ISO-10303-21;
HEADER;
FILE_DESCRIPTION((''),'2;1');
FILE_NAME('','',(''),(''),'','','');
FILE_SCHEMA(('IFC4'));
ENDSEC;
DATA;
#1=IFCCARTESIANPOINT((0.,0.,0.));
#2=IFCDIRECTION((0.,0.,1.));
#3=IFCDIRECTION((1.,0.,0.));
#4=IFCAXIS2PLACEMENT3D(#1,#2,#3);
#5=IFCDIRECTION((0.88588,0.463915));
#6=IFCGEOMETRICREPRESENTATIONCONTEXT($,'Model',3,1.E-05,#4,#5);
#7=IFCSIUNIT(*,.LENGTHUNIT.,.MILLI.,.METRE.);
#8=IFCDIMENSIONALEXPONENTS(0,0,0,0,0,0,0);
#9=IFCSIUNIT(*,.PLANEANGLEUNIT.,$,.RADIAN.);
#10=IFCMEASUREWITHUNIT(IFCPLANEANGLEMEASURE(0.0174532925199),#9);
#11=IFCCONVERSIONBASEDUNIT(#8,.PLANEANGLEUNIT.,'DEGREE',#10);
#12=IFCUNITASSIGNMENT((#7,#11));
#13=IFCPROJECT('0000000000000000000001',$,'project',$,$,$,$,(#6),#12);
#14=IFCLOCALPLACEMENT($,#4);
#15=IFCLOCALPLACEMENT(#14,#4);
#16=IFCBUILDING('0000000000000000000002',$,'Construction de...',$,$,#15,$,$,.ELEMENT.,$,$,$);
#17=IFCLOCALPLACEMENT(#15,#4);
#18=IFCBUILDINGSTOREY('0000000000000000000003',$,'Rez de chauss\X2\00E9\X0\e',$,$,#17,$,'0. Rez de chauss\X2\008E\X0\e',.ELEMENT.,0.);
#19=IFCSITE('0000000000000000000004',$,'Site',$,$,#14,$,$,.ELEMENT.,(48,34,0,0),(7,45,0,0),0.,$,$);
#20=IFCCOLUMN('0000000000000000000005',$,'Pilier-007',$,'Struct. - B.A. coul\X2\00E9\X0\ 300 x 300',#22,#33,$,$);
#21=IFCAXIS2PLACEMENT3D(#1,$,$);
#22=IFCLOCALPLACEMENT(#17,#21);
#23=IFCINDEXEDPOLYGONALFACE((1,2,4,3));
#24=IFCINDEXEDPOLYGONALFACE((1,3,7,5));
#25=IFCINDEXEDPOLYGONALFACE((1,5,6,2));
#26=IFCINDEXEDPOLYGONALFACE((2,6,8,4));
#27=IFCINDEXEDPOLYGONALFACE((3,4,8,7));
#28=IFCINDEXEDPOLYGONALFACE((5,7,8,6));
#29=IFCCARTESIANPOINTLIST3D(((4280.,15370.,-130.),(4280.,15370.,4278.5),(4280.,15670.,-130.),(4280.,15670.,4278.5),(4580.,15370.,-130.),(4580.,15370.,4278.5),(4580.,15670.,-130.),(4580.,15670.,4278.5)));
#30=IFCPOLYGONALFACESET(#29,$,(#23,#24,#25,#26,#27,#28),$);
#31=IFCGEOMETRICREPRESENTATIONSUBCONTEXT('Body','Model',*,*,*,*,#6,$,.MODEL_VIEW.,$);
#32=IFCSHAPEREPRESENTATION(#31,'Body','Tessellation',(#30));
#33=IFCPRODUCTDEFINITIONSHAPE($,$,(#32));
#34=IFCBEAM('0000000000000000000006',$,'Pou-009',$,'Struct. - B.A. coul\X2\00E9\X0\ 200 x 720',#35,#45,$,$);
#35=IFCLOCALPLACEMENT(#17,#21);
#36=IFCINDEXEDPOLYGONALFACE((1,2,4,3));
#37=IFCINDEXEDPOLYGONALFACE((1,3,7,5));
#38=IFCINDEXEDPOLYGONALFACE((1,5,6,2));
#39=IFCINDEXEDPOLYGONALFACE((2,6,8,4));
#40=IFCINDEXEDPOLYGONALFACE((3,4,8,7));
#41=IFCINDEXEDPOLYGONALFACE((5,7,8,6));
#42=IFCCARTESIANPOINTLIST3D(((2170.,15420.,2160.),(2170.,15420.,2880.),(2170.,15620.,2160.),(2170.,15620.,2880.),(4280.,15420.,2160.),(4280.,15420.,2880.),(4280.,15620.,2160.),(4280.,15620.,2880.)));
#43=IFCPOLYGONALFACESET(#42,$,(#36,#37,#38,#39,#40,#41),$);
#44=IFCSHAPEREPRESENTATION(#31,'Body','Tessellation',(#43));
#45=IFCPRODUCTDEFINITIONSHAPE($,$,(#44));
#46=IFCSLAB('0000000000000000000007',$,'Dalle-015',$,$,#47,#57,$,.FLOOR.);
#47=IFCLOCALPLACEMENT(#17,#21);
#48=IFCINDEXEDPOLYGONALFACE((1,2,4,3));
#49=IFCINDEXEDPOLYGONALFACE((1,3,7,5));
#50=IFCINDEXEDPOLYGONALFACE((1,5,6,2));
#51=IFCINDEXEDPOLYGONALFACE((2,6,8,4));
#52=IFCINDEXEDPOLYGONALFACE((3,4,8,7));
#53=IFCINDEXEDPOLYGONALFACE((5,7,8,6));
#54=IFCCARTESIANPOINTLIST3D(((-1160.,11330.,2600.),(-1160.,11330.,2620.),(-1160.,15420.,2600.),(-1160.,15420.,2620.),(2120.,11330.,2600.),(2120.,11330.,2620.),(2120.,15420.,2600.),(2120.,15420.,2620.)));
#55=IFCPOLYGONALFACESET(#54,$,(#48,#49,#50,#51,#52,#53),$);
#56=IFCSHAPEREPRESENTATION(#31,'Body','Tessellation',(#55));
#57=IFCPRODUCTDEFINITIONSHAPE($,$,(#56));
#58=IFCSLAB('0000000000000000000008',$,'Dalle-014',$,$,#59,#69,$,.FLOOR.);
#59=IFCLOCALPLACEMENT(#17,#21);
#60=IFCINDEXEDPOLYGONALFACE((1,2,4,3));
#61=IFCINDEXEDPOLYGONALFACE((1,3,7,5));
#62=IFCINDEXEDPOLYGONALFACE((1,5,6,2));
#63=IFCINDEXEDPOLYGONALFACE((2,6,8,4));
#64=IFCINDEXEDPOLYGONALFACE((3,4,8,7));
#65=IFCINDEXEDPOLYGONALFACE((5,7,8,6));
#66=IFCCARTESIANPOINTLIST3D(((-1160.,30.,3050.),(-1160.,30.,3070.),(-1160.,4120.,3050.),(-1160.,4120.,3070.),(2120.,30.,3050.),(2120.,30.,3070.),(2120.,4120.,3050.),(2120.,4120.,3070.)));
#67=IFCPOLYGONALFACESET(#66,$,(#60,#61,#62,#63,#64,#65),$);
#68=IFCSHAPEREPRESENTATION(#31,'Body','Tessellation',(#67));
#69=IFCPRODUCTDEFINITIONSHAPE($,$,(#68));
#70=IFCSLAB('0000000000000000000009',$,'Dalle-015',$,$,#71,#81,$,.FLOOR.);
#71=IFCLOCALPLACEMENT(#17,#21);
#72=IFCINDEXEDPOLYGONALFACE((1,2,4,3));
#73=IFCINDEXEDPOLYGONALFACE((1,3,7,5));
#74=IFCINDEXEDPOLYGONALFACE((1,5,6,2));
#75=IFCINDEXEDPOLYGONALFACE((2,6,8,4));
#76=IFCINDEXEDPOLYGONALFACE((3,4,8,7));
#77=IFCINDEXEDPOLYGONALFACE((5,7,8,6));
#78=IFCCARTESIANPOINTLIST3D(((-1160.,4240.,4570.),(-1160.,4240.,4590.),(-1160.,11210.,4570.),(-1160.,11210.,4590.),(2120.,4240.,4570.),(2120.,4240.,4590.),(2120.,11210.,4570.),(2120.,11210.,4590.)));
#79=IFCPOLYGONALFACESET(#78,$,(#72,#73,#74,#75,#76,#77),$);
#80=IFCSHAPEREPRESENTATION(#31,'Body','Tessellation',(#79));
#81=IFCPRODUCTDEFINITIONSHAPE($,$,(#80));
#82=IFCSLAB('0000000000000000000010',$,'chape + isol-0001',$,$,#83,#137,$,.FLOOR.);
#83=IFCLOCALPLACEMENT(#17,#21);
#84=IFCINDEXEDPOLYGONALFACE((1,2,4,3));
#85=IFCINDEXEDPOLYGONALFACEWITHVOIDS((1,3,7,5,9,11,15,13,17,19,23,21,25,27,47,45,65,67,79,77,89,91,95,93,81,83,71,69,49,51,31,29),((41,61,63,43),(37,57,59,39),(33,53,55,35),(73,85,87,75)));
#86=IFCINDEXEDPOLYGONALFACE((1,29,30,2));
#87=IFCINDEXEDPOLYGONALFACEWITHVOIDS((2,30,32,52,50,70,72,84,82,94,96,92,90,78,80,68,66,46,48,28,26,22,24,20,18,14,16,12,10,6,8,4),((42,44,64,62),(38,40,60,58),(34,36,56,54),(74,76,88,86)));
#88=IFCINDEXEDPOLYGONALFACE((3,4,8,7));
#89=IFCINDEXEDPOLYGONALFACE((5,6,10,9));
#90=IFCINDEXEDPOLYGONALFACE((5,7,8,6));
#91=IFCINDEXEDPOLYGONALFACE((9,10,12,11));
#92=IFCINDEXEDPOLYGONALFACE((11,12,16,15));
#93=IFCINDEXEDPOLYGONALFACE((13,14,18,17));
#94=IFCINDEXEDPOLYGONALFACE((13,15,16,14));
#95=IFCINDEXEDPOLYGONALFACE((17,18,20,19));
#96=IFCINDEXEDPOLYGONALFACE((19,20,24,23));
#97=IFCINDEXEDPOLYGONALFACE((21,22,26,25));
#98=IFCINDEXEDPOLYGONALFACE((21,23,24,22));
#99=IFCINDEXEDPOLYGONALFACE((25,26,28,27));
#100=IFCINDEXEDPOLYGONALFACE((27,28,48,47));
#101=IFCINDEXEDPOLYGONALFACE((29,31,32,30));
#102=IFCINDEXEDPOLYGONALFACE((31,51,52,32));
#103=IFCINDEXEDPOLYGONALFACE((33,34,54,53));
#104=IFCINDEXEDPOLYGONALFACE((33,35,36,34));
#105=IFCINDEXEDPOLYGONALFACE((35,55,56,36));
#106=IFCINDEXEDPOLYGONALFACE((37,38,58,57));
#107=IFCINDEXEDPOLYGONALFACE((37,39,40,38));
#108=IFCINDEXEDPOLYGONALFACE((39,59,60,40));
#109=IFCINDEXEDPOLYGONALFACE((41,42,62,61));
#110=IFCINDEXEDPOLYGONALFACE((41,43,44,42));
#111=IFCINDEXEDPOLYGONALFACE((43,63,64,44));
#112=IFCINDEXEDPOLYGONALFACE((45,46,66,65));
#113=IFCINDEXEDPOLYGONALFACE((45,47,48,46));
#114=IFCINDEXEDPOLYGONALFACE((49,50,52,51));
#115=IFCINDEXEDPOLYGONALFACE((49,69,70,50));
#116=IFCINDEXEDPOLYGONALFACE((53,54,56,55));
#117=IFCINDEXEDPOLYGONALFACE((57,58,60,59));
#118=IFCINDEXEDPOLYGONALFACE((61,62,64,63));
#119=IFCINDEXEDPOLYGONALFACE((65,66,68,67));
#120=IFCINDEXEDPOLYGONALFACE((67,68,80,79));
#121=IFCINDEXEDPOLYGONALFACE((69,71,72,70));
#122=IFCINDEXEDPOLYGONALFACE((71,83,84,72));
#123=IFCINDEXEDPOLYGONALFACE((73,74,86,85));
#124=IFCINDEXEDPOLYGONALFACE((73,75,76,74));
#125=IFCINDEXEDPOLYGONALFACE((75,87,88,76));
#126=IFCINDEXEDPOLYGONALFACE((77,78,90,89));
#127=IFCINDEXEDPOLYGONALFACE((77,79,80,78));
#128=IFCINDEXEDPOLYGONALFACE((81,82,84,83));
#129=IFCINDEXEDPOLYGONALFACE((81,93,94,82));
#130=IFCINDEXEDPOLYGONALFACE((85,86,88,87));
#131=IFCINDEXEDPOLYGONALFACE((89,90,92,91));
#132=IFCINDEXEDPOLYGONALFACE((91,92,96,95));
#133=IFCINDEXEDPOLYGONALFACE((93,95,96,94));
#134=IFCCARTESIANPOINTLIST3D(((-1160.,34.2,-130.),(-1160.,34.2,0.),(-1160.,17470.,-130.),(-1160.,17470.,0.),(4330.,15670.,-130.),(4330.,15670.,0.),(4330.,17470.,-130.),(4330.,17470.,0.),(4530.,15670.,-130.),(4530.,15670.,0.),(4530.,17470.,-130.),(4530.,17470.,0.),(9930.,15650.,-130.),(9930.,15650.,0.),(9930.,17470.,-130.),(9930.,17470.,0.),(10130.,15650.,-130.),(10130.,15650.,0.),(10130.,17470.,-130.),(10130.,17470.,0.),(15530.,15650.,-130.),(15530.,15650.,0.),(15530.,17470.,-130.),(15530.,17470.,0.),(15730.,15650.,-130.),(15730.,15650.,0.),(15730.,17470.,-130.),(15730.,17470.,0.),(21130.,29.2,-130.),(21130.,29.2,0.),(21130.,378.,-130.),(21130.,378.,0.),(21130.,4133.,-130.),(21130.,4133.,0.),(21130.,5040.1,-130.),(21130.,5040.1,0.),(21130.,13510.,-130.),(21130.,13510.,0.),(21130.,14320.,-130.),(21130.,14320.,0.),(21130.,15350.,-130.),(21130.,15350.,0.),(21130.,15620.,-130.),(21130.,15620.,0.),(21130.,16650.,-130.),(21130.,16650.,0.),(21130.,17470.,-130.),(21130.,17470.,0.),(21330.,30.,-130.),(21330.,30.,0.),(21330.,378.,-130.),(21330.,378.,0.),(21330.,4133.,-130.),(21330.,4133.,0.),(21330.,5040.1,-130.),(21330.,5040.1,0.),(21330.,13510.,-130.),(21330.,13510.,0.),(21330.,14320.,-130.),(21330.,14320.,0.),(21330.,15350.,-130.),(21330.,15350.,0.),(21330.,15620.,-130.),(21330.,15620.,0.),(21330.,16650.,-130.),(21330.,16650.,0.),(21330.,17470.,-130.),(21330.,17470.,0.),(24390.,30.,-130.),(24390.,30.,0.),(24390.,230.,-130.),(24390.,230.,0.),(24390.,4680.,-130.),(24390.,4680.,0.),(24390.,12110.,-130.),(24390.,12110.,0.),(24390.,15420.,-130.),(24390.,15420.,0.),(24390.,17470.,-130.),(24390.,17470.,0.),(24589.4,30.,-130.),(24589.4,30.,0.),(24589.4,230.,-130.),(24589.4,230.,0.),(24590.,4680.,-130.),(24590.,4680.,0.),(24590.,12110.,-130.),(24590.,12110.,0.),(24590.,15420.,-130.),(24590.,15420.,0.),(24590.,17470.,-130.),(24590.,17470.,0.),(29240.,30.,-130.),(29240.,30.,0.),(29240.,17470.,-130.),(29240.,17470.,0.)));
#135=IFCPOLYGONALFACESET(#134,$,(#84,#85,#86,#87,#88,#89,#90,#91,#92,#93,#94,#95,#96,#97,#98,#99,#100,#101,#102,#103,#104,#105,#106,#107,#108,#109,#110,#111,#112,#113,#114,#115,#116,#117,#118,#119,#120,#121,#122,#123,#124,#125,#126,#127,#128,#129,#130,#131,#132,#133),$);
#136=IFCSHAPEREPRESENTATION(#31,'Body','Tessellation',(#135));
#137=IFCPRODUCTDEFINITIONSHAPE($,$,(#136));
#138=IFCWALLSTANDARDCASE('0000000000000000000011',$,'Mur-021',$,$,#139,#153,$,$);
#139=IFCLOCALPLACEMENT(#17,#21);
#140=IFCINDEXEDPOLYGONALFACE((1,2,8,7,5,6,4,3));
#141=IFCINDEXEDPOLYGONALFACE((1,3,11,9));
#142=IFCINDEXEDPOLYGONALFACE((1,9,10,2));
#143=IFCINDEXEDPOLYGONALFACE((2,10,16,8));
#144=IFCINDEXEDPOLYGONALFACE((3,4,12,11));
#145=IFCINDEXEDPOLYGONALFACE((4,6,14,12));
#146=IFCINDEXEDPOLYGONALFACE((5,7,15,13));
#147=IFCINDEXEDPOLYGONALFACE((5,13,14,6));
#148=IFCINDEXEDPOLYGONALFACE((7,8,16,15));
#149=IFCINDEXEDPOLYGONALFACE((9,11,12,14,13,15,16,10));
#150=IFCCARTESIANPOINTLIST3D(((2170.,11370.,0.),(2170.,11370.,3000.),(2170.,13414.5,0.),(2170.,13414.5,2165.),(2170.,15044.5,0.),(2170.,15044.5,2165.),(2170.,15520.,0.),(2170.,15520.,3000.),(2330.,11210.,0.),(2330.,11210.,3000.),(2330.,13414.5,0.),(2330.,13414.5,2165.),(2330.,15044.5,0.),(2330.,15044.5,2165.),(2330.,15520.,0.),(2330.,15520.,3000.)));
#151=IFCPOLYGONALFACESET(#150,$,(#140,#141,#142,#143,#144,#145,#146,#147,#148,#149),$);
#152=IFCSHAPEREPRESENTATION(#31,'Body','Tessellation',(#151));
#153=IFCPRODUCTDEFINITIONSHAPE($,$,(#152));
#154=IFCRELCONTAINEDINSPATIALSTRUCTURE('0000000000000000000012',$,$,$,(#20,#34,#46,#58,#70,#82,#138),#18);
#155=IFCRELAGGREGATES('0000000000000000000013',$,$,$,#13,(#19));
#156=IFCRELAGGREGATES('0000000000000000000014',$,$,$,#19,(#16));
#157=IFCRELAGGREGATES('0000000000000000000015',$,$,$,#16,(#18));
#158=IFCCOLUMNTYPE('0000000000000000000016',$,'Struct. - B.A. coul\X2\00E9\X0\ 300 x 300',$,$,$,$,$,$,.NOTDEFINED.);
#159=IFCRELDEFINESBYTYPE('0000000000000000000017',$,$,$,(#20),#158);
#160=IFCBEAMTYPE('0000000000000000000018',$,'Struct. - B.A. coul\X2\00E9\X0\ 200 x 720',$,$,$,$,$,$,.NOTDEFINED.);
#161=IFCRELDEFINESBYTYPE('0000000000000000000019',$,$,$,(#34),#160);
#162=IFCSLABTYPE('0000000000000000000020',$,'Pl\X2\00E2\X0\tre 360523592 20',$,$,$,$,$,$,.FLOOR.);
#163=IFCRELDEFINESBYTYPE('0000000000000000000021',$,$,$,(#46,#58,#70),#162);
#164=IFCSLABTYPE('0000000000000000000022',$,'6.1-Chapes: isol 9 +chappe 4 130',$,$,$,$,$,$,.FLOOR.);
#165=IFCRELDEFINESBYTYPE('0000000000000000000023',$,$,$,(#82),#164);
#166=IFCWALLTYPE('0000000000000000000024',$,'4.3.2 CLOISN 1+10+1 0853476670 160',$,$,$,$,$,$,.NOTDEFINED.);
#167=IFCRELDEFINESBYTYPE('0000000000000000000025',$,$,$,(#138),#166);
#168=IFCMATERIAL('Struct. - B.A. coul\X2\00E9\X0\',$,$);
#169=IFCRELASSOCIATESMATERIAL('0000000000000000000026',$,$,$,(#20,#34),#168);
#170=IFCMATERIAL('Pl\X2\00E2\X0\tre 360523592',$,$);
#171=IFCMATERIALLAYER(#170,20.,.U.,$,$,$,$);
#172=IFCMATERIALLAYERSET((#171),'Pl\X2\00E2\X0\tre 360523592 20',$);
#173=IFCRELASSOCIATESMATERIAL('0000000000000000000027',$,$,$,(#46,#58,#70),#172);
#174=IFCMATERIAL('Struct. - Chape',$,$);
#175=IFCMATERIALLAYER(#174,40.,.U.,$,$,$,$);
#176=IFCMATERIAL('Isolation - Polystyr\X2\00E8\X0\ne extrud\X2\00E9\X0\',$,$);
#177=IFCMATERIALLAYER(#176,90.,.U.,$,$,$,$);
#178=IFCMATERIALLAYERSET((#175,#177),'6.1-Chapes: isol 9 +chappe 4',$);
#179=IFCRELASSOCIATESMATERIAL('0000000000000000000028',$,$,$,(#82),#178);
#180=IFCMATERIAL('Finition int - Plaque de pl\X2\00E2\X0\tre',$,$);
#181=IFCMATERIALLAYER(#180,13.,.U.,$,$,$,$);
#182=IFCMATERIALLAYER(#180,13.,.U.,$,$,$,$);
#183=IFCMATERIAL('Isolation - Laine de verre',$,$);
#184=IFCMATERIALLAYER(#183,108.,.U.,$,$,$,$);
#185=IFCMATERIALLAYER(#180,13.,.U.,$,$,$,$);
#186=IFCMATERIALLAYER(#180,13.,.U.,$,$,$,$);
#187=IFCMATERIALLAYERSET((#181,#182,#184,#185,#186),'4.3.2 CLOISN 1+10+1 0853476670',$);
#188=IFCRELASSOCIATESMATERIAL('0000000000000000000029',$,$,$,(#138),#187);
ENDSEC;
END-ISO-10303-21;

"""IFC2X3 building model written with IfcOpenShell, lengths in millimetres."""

from ifc_helpers import new_model, entity, si_unit, converted_unit, direction, frame, frame_2d, origin_with_axes, origin_2d_with_axis, place, context, subcontext, project, spatial, polyline, rectangle, outline, extrude, material, layer, layer_set, layer_usage, type_object, element, save


model = new_model("IFC2X3")

# Units and contexts
model_context = context("Model", 3, precision=1e-05, world=origin_with_axes(), true_north=direction((0.88588, 0.463915)))
body_context = subcontext(model_context, "Body", "Model", "MODEL_VIEW")
ifc_project = project(units=[si_unit("LENGTHUNIT", "METRE", prefix="MILLI"), converted_unit("PLANEANGLEUNIT", "DEGREE", entity("IfcPlaneAngleMeasure", 0.0174532925199), si_unit("PLANEANGLEUNIT", "RADIAN"), dimensions=[0, 0, 0, 0, 0, 0, 0])], contexts=[model_context])

# Site, building, storey
site_placement = place(None, origin_with_axes())
site = spatial("IfcSite", under=ifc_project, at=site_placement, Name="Site", CompositionType="ELEMENT", RefLatitude=(48, 34, 0, 0), RefLongitude=(7, 45, 0, 0), RefElevation=0.0)
building_placement = place(site_placement, origin_with_axes())
building = spatial("IfcBuilding", under=site, at=building_placement, Name="Construction de...", CompositionType="ELEMENT")
storey_placement = place(building_placement, origin_with_axes())
storey = spatial("IfcBuildingStorey", under=building, at=storey_placement, Name="Rez de chaussée", LongName="0. Rez de chauss\u008ee", CompositionType="ELEMENT", Elevation=0.0)

# Column
ifc_material_1 = material(Name="Struct. - B.A. coulé")
column_type = type_object("IfcColumnType", Name="Struct. - B.A. coulé 300 x 300", PredefinedType="NOTDEFINED")
column_placement = place(storey_placement, frame((4430.0, 15520.0, -130.0), z_axis=(0.0, 0.0, 1.0), x_axis=(1.0, 0.0, 0.0)))
element("IfcColumn", 1, at=column_placement, inside=storey, type_object=column_type, material=ifc_material_1, Name="Pilier-007", ObjectType="Struct. - B.A. coulé 300 x 300", context=body_context, shape_type="SweptSolid", body=[
    extrude(rectangle(XDim=300.0, YDim=300.0, at=origin_2d_with_axis()), origin_with_axes(), (0.0, 0.0, 1.0), 4408.5),
])

# Beam
beam_type = type_object("IfcBeamType", Name="Struct. - B.A. coulé 200 x 720", PredefinedType="NOTDEFINED")
beam_placement = place(storey_placement, frame((4280.0, 15620.0, 2880.0), z_axis=(0.0, 0.0, 1.0), x_axis=(0.0, 1.0, 0.0)))
element("IfcBeam", 2, at=beam_placement, inside=storey, type_object=beam_type, material=ifc_material_1, Name="Pou-009", ObjectType="Struct. - B.A. coulé 200 x 720", context=body_context, shape_type="SweptSolid", body=[
    extrude(rectangle(XDim=720.0, YDim=200.0, at=frame_2d((-360.0, -100.0), x_axis=(1.0, 0.0))), frame((0.0, 0.0, 0.0), z_axis=(0.0, 1.0, 0.0), x_axis=(0.0, 0.0, 1.0)), (0.0, 0.0, 1.0), 2110.0),
])

# Slabs
ifc_material_2 = material(Name="Plâtre 360523592")
ifc_layer_1 = layer(ifc_material_2, 20.0, ventilated="UNKNOWN")
ifc_layer_set_1 = layer_set([ifc_layer_1], Name="Plâtre 360523592 20")
ifc_layer_usage_1 = layer_usage(ifc_layer_set_1, "AXIS3", "NEGATIVE", 20.0)
slab_type_1 = type_object("IfcSlabType", Name="Plâtre 360523592 20", PredefinedType="FLOOR")
slab_1_placement = place(storey_placement, frame((2120.0, 11330.0, 2620.0), z_axis=(0.0, 0.0, 1.0), x_axis=(1.0, 0.0, 0.0)))
element("IfcSlab", 3, at=slab_1_placement, inside=storey, type_object=slab_type_1, material=ifc_layer_usage_1, Name="Dalle-015", PredefinedType="FLOOR", context=body_context, shape_type="SweptSolid", body=[
    extrude(outline(polyline([(0.0, 0.0), (0.0, 4090.0), (-3280.0, 4090.0), (-3280.0, 0.0), (0.0, 0.0)])), frame((0.0, 0.0, -20.0), z_axis=(0.0, 0.0, 1.0), x_axis=(1.0, 0.0, 0.0)), (0.0, 0.0, 1.0), 20.0),
])
ifc_layer_usage_2 = layer_usage(ifc_layer_set_1, "AXIS3", "NEGATIVE", 20.0)
slab_2_placement = place(storey_placement, frame((2120.0, 4120.0, 3070.0), z_axis=(0.0, 0.0, 1.0), x_axis=(1.0, 0.0, 0.0)))
element("IfcSlab", 4, at=slab_2_placement, inside=storey, type_object=slab_type_1, material=ifc_layer_usage_2, Name="Dalle-014", PredefinedType="FLOOR", context=body_context, shape_type="SweptSolid", body=[
    extrude(outline(polyline([(0.0, 0.0), (-3280.0, 0.0), (-3280.0, -4090.0), (0.0, -4090.0), (0.0, 0.0)])), frame((0.0, 0.0, -20.0), z_axis=(0.0, 0.0, 1.0), x_axis=(1.0, 0.0, 0.0)), (0.0, 0.0, 1.0), 20.0),
])
ifc_layer_usage_3 = layer_usage(ifc_layer_set_1, "AXIS3", "NEGATIVE", 20.0)
slab_3_placement = place(storey_placement, frame((-1160.0, 11210.0, 4590.0), z_axis=(0.0, 0.0, 1.0), x_axis=(1.0, 0.0, 0.0)))
element("IfcSlab", 5, at=slab_3_placement, inside=storey, type_object=slab_type_1, material=ifc_layer_usage_3, Name="Dalle-015", PredefinedType="FLOOR", context=body_context, shape_type="SweptSolid", body=[
    extrude(outline(polyline([(0.0, 0.0), (0.0, -6970.0), (3280.0, -6970.0), (3280.0, 0.0), (0.0, 0.0)])), frame((0.0, 0.0, -20.0), z_axis=(0.0, 0.0, 1.0), x_axis=(1.0, 0.0, 0.0)), (0.0, 0.0, 1.0), 20.0),
])

# Slab, openings
ifc_material_3 = material(Name="Struct. - Chape")
ifc_layer_2 = layer(ifc_material_3, 40.0, ventilated="UNKNOWN")
ifc_material_4 = material(Name="Isolation - Polystyrène extrudé")
ifc_layer_3 = layer(ifc_material_4, 90.0, ventilated="UNKNOWN")
ifc_layer_set_2 = layer_set([ifc_layer_2, ifc_layer_3], Name="6.1-Chapes: isol 9 +chappe 4")
ifc_layer_usage_4 = layer_usage(ifc_layer_set_2, "AXIS3", "NEGATIVE", 130.0)
slab_type_2 = type_object("IfcSlabType", Name="6.1-Chapes: isol 9 +chappe 4 130", PredefinedType="FLOOR")
slab_4_placement = place(storey_placement, frame((-1160.0, 34.2, 0.0), z_axis=(0.0, 0.0, 1.0), x_axis=(1.0, 0.0, 0.0)))
slab_4 = element("IfcSlab", 6, at=slab_4_placement, inside=storey, type_object=slab_type_2, material=ifc_layer_usage_4, Name="chape + isol-0001", PredefinedType="FLOOR", context=body_context, shape_type="SweptSolid", body=[
    extrude(outline(polyline([(0.0, 0.0), (22290.0, -5.0), (22290.0, 343.8), (22490.0, 343.8), (22490.0, -4.2), (25550.0, -4.2), (25550.0, 195.8), (25749.4, 195.8), (25749.4, -4.2), (30400.0, -4.2), (30400.0, 17435.8), (25750.0, 17435.8), (25750.0, 15385.8), (25550.0, 15385.8), (25550.0, 17435.8), (22490.0, 17435.8), (22490.0, 16615.8), (22290.0, 16615.8), (22290.0, 17435.8), (16890.0, 17435.8), (16890.0, 15615.8), (16690.0, 15615.8), (16690.0, 17435.8), (11290.0, 17435.8), (11290.0, 15615.8), (11090.0, 15615.8), (11090.0, 17435.8), (5690.0, 17435.8), (5690.0, 15635.8), (5490.0, 15635.8), (5490.0, 17435.8), (0.0, 17435.8), (0.0, 0.0)])), frame((0.0, 0.0, -130.0), z_axis=(0.0, 0.0, 1.0), x_axis=(1.0, 0.0, 0.0)), (0.0, 0.0, 1.0), 130.0),
])
opening_1_placement = place(slab_4_placement, origin_with_axes())
element("IfcOpeningElement", 7, at=opening_1_placement, cuts=slab_4, context=body_context, shape_type="SweptSolid", body=[
    extrude(outline(polyline([(22290.0, 15585.8), (22290.0, 15315.8), (22490.0, 15315.8), (22490.0, 15585.8), (22290.0, 15585.8)])), frame((0.0, 0.0, -130.0), z_axis=(0.0, 0.0, 1.0), x_axis=(1.0, 0.0, 0.0)), (0.0, 0.0, 1.0), 130.0),
])
opening_2_placement = place(slab_4_placement, origin_with_axes())
element("IfcOpeningElement", 8, at=opening_2_placement, cuts=slab_4, context=body_context, shape_type="SweptSolid", body=[
    extrude(outline(polyline([(22290.0, 4098.8), (22490.0, 4098.8), (22490.0, 5005.9), (22290.0, 5005.9), (22290.0, 4098.8)])), frame((0.0, 0.0, -130.0), z_axis=(0.0, 0.0, 1.0), x_axis=(1.0, 0.0, 0.0)), (0.0, 0.0, 1.0), 130.0),
])
opening_3_placement = place(slab_4_placement, origin_with_axes())
element("IfcOpeningElement", 9, at=opening_3_placement, cuts=slab_4, context=body_context, shape_type="SweptSolid", body=[
    extrude(outline(polyline([(22290.0, 13475.8), (22490.0, 13475.8), (22490.0, 14285.8), (22290.0, 14285.8), (22290.0, 13475.8)])), frame((0.0, 0.0, -130.0), z_axis=(0.0, 0.0, 1.0), x_axis=(1.0, 0.0, 0.0)), (0.0, 0.0, 1.0), 130.0),
])
opening_4_placement = place(slab_4_placement, origin_with_axes())
element("IfcOpeningElement", 10, at=opening_4_placement, cuts=slab_4, context=body_context, shape_type="SweptSolid", body=[
    extrude(outline(polyline([(25550.0, 12075.8), (25550.0, 4645.8), (25750.0, 4645.8), (25750.0, 12075.8), (25550.0, 12075.8)])), frame((0.0, 0.0, -130.0), z_axis=(0.0, 0.0, 1.0), x_axis=(1.0, 0.0, 0.0)), (0.0, 0.0, 1.0), 130.0),
])

# Shared definitions
ifc_material_5 = material(Name="Finition int - Plaque de plâtre")
ifc_layer_4 = layer(ifc_material_5, 13.0, ventilated="UNKNOWN")
ifc_layer_5 = layer(ifc_material_5, 13.0, ventilated="UNKNOWN")
ifc_material_6 = material(Name="Isolation - Laine de verre")
ifc_layer_6 = layer(ifc_material_6, 108.0, ventilated="UNKNOWN")
ifc_layer_7 = layer(ifc_material_5, 13.0, ventilated="UNKNOWN")
ifc_layer_8 = layer(ifc_material_5, 13.0, ventilated="UNKNOWN")
ifc_layer_set_3 = layer_set([ifc_layer_4, ifc_layer_5, ifc_layer_6, ifc_layer_7, ifc_layer_8], Name="4.3.2 CLOISN 1+10+1 0853476670")
wall_type_1 = type_object("IfcWallType", Name="4.3.2 CLOISN 1+10+1 0853476670 160", PredefinedType="NOTDEFINED")

# Wall, opening
ifc_layer_usage_5 = layer_usage(ifc_layer_set_3, "AXIS2", "NEGATIVE", 80.0)
wall_1_placement = place(storey_placement, frame((2250.0, 11290.0, 0.0), z_axis=(0.0, 0.0, 1.0), x_axis=(0.0, 1.0, 0.0)))
wall_1 = element("IfcWallStandardCase", 11, at=wall_1_placement, inside=storey, type_object=wall_type_1, material=ifc_layer_usage_5, Name="Mur-021", context=body_context, shape_type="SweptSolid", body=[
    extrude(outline(polyline([(-80.0, -80.0), (4230.0, -80.0), (4230.0, 80.0), (80.0, 80.0), (-80.0, -80.0)])), origin_with_axes(), (0.0, 0.0, 1.0), 3000.0),
])
opening_5_placement = place(wall_1_placement, frame((2939.5, 0.0, 0.0), z_axis=(0.0, 0.0, 1.0), x_axis=(1.0, 0.0, 0.0)))
element("IfcOpeningElement", 12, at=opening_5_placement, cuts=wall_1, context=body_context, shape_type="SweptSolid", body=[
    extrude(rectangle(XDim=1630.0, YDim=2165.0, at=origin_2d_with_axis()), frame((0.0, -160.0, 1082.5), z_axis=(0.0, 1.0, 0.0), x_axis=(1.0, 0.0, 0.0)), (0.0, 0.0, 1.0), 480.0),
])

save(model, "model.ifc")
